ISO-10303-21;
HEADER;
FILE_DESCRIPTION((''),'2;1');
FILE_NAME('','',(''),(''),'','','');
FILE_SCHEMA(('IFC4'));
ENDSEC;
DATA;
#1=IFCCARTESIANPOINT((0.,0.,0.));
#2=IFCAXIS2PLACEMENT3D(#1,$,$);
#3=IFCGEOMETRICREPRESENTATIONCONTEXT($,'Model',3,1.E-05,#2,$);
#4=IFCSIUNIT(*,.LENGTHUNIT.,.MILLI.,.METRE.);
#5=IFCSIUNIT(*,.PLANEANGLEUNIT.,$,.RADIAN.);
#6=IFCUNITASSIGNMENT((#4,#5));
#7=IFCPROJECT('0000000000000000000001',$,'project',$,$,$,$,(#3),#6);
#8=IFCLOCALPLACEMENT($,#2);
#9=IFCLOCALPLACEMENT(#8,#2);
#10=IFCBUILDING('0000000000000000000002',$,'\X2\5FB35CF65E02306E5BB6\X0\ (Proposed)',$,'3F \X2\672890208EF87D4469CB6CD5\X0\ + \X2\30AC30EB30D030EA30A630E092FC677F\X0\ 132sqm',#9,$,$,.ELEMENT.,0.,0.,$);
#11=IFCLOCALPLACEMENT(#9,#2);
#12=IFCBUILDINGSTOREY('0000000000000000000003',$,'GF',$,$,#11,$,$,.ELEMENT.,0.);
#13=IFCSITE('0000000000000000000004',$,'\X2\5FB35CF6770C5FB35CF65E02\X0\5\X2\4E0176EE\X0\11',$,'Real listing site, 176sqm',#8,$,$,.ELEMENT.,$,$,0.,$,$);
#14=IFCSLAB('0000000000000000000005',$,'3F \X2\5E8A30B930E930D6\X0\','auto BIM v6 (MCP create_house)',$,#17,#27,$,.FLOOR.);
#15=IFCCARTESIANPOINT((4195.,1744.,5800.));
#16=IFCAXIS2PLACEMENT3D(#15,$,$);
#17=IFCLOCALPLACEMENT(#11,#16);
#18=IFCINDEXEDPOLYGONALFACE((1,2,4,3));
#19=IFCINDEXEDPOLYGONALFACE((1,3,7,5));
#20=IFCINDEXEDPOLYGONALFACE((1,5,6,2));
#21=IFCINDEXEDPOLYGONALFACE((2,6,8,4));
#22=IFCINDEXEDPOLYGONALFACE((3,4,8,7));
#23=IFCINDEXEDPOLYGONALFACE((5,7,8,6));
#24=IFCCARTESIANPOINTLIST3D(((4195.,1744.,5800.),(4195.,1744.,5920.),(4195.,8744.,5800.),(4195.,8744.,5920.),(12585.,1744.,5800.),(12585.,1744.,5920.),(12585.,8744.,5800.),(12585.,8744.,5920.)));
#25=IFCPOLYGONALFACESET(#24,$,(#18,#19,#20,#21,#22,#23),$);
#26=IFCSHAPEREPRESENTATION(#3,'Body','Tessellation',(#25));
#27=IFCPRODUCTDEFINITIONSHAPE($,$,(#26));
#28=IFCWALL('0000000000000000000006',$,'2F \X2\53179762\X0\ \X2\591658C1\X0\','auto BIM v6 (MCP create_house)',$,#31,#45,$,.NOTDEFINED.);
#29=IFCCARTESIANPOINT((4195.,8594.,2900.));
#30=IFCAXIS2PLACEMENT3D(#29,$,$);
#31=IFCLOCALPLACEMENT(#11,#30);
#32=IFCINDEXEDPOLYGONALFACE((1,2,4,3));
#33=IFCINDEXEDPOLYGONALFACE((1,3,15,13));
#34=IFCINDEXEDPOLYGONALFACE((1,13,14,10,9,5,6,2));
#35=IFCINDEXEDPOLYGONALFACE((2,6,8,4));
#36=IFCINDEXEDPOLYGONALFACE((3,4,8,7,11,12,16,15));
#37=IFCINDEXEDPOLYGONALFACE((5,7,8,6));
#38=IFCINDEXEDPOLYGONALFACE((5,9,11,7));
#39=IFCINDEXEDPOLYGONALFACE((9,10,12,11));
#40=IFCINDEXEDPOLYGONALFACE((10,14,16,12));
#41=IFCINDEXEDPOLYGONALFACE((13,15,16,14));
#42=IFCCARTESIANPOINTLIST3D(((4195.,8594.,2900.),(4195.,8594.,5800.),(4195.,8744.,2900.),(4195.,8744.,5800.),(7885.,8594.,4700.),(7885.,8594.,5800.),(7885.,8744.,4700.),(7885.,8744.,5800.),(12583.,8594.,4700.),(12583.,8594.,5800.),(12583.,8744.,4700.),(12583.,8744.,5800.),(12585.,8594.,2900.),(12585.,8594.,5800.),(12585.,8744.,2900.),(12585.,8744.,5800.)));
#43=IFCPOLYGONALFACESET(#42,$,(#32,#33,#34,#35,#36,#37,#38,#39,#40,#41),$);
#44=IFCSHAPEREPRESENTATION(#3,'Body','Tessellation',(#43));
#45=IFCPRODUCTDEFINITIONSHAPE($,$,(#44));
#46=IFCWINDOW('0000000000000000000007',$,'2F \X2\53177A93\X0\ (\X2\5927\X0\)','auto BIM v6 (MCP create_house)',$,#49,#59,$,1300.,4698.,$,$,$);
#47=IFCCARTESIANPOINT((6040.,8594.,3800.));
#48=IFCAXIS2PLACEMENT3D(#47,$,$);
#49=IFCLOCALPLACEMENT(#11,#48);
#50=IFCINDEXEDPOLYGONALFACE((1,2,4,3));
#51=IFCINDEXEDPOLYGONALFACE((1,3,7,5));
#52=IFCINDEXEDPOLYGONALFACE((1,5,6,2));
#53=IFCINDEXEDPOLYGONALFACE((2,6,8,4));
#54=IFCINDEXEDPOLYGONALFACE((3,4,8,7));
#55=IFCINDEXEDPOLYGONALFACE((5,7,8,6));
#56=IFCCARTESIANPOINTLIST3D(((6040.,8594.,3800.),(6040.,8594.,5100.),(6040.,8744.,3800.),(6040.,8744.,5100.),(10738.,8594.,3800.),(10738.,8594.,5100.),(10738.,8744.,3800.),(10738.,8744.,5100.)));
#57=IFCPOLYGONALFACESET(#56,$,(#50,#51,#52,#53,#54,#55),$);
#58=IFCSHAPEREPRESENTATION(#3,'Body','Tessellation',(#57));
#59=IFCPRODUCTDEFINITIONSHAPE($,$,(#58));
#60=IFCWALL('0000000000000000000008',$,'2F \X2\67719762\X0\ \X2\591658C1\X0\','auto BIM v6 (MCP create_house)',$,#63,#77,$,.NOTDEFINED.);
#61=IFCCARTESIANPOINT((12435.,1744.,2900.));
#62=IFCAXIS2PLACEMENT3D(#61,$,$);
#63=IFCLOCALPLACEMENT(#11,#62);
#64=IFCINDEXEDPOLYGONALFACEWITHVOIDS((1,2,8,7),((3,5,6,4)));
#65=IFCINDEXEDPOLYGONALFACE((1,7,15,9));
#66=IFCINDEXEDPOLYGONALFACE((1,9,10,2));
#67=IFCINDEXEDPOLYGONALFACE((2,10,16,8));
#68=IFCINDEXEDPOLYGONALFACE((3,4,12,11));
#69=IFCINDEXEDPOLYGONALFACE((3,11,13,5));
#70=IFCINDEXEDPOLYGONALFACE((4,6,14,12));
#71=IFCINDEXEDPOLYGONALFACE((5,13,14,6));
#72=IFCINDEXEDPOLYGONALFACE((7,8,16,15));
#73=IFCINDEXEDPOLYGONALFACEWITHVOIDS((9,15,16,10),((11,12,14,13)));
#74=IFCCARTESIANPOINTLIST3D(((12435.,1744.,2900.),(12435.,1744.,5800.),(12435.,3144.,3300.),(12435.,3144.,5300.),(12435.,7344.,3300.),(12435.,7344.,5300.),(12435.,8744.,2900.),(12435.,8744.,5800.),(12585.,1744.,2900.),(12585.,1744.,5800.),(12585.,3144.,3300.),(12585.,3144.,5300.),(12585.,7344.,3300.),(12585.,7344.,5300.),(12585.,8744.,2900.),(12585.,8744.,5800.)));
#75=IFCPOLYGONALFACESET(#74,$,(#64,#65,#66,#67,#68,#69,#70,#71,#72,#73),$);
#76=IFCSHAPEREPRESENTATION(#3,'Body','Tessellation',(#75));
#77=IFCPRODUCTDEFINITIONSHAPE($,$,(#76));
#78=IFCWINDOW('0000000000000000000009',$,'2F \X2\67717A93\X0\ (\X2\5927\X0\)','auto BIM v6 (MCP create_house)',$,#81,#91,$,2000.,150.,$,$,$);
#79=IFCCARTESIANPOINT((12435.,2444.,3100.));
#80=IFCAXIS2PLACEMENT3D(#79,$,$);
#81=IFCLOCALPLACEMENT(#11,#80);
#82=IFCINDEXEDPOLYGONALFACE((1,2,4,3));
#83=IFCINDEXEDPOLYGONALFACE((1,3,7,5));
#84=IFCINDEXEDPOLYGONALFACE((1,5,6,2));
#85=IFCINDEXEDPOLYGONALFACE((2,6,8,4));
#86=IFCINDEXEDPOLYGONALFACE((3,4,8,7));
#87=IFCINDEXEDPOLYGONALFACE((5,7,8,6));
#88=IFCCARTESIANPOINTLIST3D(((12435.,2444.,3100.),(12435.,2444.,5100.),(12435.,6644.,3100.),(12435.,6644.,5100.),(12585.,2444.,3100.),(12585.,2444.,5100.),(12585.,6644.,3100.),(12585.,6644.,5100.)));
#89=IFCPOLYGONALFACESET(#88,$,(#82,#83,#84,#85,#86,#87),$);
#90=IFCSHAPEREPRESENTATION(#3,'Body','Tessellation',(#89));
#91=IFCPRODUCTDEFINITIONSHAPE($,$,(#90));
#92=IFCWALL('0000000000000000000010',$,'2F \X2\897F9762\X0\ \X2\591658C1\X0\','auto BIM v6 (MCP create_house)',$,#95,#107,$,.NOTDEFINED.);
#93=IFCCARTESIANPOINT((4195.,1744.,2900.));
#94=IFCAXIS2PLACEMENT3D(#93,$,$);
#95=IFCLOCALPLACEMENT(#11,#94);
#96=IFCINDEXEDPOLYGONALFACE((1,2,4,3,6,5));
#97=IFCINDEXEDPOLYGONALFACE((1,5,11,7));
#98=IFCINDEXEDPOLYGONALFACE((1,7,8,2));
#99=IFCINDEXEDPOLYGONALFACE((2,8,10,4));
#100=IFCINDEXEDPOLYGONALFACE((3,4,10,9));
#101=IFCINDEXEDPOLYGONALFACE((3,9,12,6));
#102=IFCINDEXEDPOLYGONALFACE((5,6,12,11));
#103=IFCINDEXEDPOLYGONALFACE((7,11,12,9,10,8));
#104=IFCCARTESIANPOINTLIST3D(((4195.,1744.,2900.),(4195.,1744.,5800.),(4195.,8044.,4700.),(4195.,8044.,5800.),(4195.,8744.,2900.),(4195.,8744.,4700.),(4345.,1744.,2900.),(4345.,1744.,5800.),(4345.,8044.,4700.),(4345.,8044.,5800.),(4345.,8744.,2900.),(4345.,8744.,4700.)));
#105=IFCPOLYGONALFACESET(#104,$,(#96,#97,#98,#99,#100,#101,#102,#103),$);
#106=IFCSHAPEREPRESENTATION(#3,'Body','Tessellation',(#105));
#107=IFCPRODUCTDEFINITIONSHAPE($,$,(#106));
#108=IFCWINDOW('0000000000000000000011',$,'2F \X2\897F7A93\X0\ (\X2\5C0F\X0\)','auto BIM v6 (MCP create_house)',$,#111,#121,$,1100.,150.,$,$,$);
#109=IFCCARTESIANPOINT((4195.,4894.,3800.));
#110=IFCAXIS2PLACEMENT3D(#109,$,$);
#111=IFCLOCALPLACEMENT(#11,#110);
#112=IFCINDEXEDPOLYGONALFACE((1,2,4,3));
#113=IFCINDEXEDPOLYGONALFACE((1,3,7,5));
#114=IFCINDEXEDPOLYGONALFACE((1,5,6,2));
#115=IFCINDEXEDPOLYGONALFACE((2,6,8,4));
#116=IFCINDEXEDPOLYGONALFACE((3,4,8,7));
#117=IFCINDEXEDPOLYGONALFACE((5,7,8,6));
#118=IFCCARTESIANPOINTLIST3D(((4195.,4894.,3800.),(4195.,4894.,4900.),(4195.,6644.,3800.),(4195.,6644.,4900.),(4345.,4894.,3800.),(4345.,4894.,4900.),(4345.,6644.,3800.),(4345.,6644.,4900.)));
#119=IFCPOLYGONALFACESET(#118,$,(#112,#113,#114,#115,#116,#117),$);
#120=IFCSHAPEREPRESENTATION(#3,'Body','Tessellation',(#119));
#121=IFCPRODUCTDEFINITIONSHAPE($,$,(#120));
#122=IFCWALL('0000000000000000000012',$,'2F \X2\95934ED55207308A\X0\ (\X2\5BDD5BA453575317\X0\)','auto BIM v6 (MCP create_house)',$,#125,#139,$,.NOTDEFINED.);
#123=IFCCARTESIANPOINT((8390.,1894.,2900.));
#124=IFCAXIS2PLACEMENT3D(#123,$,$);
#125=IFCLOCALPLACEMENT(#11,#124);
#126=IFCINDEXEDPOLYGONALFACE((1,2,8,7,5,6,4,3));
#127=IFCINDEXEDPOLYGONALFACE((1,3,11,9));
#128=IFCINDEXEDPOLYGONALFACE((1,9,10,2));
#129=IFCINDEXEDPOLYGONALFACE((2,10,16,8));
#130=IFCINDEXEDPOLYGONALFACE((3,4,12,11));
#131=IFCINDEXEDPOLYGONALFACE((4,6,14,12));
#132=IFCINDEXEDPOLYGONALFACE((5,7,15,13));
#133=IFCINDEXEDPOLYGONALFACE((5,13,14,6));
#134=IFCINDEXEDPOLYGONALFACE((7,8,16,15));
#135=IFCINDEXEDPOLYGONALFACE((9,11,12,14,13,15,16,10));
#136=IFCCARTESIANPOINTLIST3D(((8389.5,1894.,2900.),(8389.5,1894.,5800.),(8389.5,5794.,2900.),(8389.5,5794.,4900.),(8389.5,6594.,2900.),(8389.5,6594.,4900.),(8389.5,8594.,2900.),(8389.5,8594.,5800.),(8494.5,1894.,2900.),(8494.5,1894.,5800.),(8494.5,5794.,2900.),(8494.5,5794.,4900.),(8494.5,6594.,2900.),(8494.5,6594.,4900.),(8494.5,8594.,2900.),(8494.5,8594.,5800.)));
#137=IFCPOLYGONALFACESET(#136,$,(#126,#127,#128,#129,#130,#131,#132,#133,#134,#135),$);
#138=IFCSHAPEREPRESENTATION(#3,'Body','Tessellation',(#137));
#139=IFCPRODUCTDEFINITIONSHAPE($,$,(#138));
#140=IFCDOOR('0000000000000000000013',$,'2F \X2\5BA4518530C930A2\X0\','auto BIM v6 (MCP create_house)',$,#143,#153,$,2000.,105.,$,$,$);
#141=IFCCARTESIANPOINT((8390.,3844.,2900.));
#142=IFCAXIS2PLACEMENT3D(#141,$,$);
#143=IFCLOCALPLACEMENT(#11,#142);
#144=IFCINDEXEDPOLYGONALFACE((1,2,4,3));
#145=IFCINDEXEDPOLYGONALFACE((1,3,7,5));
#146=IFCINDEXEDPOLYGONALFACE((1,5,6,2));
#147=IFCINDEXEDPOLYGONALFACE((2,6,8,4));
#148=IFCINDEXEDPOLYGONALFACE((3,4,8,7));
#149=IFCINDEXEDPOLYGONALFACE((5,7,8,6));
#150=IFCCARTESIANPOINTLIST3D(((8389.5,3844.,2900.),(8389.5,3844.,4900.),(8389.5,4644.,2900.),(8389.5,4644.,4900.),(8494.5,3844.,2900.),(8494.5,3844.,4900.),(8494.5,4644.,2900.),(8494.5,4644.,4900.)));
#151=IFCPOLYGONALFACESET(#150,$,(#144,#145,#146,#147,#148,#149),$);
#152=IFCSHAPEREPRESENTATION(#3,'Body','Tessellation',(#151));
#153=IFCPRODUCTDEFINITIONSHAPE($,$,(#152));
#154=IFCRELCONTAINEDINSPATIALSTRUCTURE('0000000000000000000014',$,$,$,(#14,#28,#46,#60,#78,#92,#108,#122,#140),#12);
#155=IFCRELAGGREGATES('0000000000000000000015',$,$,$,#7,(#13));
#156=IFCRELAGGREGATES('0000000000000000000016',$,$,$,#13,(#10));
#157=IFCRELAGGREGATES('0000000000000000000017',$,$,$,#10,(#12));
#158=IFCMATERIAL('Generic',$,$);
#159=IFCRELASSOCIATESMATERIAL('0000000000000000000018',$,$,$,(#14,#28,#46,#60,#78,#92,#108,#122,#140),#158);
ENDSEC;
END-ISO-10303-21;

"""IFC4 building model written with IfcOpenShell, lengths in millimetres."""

from ifc_helpers import new_model, si_unit, frame, frame_2d, origin, place, context, project, spatial, rectangle, extrude, material, element, fill, save


model = new_model("IFC4")

# Units and contexts
model_context = context("Model", 3, precision=1e-05, world=origin())
ifc_project = project(units=[si_unit("LENGTHUNIT", "METRE", prefix="MILLI"), si_unit("PLANEANGLEUNIT", "RADIAN")], contexts=[model_context])

# Site, building, storey
site_placement = place(None, origin())
site = spatial("IfcSite", under=ifc_project, at=site_placement, Name="徳島県徳島市5丁目11", ObjectType="Real listing site, 176sqm", CompositionType="ELEMENT", RefElevation=0.0)
building_placement = place(site_placement, origin())
building = spatial("IfcBuilding", under=site, at=building_placement, Name="徳島市の家 (Proposed)", ObjectType="3F 木造軸組構法 + ガルバリウム鋼板 132sqm", CompositionType="ELEMENT", ElevationOfRefHeight=0.0, ElevationOfTerrain=0.0)
storey_placement = place(building_placement, origin())
storey = spatial("IfcBuildingStorey", under=building, at=storey_placement, Name="GF", CompositionType="ELEMENT", Elevation=0.0)

# Slab
ifc_material = material(Name="Generic")
slab_placement = place(storey_placement, frame((4195.0, 1744.0, 5800.0)))
element("IfcSlab", 1, at=slab_placement, inside=storey, material=ifc_material, Name="3F 床スラブ", Description="auto BIM v6 (MCP create_house)", PredefinedType="FLOOR", context=model_context, shape_type="SweptSolid", body=[
    extrude(rectangle(XDim=8390.0, YDim=7000.0, at=frame_2d((4195.0, 3500.0))), frame((4195.0, 1744.0, 5800.0)), (0.0, 0.0, 1.0), 120.0),
])

# Walls, openings, windows
wall_1_placement = place(storey_placement, frame((4195.0, 8594.0, 2900.0)))
wall_1 = element("IfcWall", 2, at=wall_1_placement, inside=storey, material=ifc_material, Name="2F 北面 外壁", Description="auto BIM v6 (MCP create_house)", PredefinedType="NOTDEFINED", context=model_context, shape_type="SweptSolid", body=[
    extrude(rectangle(XDim=8390.0, YDim=150.0, at=frame_2d((4195.0, 75.0))), frame((4195.0, 8594.0, 2900.0)), (0.0, 0.0, 1.0), 2900.0),
])
opening_1_placement = place(storey_placement, frame((6040.0, 8594.0, 3800.0)))
opening_1 = element("IfcOpeningElement", 3, at=opening_1_placement, cuts=wall_1, PredefinedType="NOTDEFINED", context=model_context, shape_type="SweptSolid", body=[
    extrude(rectangle(XDim=4698.0, YDim=150.0, at=frame_2d((2349.0, 75.0))), frame((6040.0, 8594.0, 3800.0)), (0.0, 0.0, 1.0), 1300.0),
])
window_1_placement = place(storey_placement, frame((6040.0, 8594.0, 3800.0)))
window_1 = element("IfcWindow", 4, at=window_1_placement, inside=storey, material=ifc_material, Name="2F 北窓 (大)", Description="auto BIM v6 (MCP create_house)", OverallHeight=1300.0, OverallWidth=4698.0, context=model_context, shape_type="SweptSolid", body=[
    extrude(rectangle(XDim=4698.0, YDim=150.0, at=frame_2d((2349.0, 75.0))), frame((6040.0, 8594.0, 3800.0)), (0.0, 0.0, 1.0), 1300.0),
])
fill(opening_1, window_1)
wall_2_placement = place(storey_placement, frame((12435.0, 1744.0, 2900.0)))
wall_2 = element("IfcWall", 5, at=wall_2_placement, inside=storey, material=ifc_material, Name="2F 東面 外壁", Description="auto BIM v6 (MCP create_house)", PredefinedType="NOTDEFINED", context=model_context, shape_type="SweptSolid", body=[
    extrude(rectangle(XDim=150.0, YDim=7000.0, at=frame_2d((75.0, 3500.0))), frame((12435.0, 1744.0, 2900.0)), (0.0, 0.0, 1.0), 2900.0),
])
opening_2_placement = place(storey_placement, frame((12435.0, 2444.0, 3100.0)))
opening_2 = element("IfcOpeningElement", 6, at=opening_2_placement, cuts=wall_2, PredefinedType="NOTDEFINED", context=model_context, shape_type="SweptSolid", body=[
    extrude(rectangle(XDim=150.0, YDim=4200.0, at=frame_2d((75.0, 2100.0))), frame((12435.0, 2444.0, 3100.0)), (0.0, 0.0, 1.0), 2000.0),
])
window_2_placement = place(storey_placement, frame((12435.0, 2444.0, 3100.0)))
window_2 = element("IfcWindow", 7, at=window_2_placement, inside=storey, material=ifc_material, Name="2F 東窓 (大)", Description="auto BIM v6 (MCP create_house)", OverallHeight=2000.0, OverallWidth=150.0, context=model_context, shape_type="SweptSolid", body=[
    extrude(rectangle(XDim=150.0, YDim=4200.0, at=frame_2d((75.0, 2100.0))), frame((12435.0, 2444.0, 3100.0)), (0.0, 0.0, 1.0), 2000.0),
])
fill(opening_2, window_2)
wall_3_placement = place(storey_placement, frame((4195.0, 1744.0, 2900.0)))
wall_3 = element("IfcWall", 8, at=wall_3_placement, inside=storey, material=ifc_material, Name="2F 西面 外壁", Description="auto BIM v6 (MCP create_house)", PredefinedType="NOTDEFINED", context=model_context, shape_type="SweptSolid", body=[
    extrude(rectangle(XDim=150.0, YDim=7000.0, at=frame_2d((75.0, 3500.0))), frame((4195.0, 1744.0, 2900.0)), (0.0, 0.0, 1.0), 2900.0),
])
opening_3_placement = place(storey_placement, frame((4195.0, 4894.0, 3800.0)))
opening_3 = element("IfcOpeningElement", 9, at=opening_3_placement, cuts=wall_3, PredefinedType="NOTDEFINED", context=model_context, shape_type="SweptSolid", body=[
    extrude(rectangle(XDim=150.0, YDim=1750.0, at=frame_2d((75.0, 875.0))), frame((4195.0, 4894.0, 3800.0)), (0.0, 0.0, 1.0), 1100.0),
])
window_3_placement = place(storey_placement, frame((4195.0, 4894.0, 3800.0)))
window_3 = element("IfcWindow", 10, at=window_3_placement, inside=storey, material=ifc_material, Name="2F 西窓 (小)", Description="auto BIM v6 (MCP create_house)", OverallHeight=1100.0, OverallWidth=150.0, context=model_context, shape_type="SweptSolid", body=[
    extrude(rectangle(XDim=150.0, YDim=1750.0, at=frame_2d((75.0, 875.0))), frame((4195.0, 4894.0, 3800.0)), (0.0, 0.0, 1.0), 1100.0),
])
fill(opening_3, window_3)

# Wall, opening, door
wall_4_placement = place(storey_placement, frame((8390.0, 1894.0, 2900.0)))
wall_4 = element("IfcWall", 11, at=wall_4_placement, inside=storey, material=ifc_material, Name="2F 間仕切り (寝室南北)", Description="auto BIM v6 (MCP create_house)", PredefinedType="NOTDEFINED", context=model_context, shape_type="SweptSolid", body=[
    extrude(rectangle(XDim=105.0, YDim=6700.0, at=frame_2d((52.0, 3350.0))), frame((8390.0, 1894.0, 2900.0)), (0.0, 0.0, 1.0), 2900.0),
])
opening_4_placement = place(storey_placement, frame((8390.0, 3844.0, 2900.0)))
opening_4 = element("IfcOpeningElement", 12, at=opening_4_placement, cuts=wall_4, PredefinedType="NOTDEFINED", context=model_context, shape_type="SweptSolid", body=[
    extrude(rectangle(XDim=105.0, YDim=800.0, at=frame_2d((52.0, 400.0))), frame((8390.0, 3844.0, 2900.0)), (0.0, 0.0, 1.0), 2000.0),
])
door_1_placement = place(storey_placement, frame((8390.0, 3844.0, 2900.0)))
door_1 = element("IfcDoor", 13, at=door_1_placement, inside=storey, material=ifc_material, Name="2F 室内ドア", Description="auto BIM v6 (MCP create_house)", OverallHeight=2000.0, OverallWidth=105.0, context=model_context, shape_type="SweptSolid", body=[
    extrude(rectangle(XDim=105.0, YDim=800.0, at=frame_2d((52.0, 400.0))), frame((8390.0, 3844.0, 2900.0)), (0.0, 0.0, 1.0), 2000.0),
])
fill(opening_4, door_1)

save(model, "model.ifc")
